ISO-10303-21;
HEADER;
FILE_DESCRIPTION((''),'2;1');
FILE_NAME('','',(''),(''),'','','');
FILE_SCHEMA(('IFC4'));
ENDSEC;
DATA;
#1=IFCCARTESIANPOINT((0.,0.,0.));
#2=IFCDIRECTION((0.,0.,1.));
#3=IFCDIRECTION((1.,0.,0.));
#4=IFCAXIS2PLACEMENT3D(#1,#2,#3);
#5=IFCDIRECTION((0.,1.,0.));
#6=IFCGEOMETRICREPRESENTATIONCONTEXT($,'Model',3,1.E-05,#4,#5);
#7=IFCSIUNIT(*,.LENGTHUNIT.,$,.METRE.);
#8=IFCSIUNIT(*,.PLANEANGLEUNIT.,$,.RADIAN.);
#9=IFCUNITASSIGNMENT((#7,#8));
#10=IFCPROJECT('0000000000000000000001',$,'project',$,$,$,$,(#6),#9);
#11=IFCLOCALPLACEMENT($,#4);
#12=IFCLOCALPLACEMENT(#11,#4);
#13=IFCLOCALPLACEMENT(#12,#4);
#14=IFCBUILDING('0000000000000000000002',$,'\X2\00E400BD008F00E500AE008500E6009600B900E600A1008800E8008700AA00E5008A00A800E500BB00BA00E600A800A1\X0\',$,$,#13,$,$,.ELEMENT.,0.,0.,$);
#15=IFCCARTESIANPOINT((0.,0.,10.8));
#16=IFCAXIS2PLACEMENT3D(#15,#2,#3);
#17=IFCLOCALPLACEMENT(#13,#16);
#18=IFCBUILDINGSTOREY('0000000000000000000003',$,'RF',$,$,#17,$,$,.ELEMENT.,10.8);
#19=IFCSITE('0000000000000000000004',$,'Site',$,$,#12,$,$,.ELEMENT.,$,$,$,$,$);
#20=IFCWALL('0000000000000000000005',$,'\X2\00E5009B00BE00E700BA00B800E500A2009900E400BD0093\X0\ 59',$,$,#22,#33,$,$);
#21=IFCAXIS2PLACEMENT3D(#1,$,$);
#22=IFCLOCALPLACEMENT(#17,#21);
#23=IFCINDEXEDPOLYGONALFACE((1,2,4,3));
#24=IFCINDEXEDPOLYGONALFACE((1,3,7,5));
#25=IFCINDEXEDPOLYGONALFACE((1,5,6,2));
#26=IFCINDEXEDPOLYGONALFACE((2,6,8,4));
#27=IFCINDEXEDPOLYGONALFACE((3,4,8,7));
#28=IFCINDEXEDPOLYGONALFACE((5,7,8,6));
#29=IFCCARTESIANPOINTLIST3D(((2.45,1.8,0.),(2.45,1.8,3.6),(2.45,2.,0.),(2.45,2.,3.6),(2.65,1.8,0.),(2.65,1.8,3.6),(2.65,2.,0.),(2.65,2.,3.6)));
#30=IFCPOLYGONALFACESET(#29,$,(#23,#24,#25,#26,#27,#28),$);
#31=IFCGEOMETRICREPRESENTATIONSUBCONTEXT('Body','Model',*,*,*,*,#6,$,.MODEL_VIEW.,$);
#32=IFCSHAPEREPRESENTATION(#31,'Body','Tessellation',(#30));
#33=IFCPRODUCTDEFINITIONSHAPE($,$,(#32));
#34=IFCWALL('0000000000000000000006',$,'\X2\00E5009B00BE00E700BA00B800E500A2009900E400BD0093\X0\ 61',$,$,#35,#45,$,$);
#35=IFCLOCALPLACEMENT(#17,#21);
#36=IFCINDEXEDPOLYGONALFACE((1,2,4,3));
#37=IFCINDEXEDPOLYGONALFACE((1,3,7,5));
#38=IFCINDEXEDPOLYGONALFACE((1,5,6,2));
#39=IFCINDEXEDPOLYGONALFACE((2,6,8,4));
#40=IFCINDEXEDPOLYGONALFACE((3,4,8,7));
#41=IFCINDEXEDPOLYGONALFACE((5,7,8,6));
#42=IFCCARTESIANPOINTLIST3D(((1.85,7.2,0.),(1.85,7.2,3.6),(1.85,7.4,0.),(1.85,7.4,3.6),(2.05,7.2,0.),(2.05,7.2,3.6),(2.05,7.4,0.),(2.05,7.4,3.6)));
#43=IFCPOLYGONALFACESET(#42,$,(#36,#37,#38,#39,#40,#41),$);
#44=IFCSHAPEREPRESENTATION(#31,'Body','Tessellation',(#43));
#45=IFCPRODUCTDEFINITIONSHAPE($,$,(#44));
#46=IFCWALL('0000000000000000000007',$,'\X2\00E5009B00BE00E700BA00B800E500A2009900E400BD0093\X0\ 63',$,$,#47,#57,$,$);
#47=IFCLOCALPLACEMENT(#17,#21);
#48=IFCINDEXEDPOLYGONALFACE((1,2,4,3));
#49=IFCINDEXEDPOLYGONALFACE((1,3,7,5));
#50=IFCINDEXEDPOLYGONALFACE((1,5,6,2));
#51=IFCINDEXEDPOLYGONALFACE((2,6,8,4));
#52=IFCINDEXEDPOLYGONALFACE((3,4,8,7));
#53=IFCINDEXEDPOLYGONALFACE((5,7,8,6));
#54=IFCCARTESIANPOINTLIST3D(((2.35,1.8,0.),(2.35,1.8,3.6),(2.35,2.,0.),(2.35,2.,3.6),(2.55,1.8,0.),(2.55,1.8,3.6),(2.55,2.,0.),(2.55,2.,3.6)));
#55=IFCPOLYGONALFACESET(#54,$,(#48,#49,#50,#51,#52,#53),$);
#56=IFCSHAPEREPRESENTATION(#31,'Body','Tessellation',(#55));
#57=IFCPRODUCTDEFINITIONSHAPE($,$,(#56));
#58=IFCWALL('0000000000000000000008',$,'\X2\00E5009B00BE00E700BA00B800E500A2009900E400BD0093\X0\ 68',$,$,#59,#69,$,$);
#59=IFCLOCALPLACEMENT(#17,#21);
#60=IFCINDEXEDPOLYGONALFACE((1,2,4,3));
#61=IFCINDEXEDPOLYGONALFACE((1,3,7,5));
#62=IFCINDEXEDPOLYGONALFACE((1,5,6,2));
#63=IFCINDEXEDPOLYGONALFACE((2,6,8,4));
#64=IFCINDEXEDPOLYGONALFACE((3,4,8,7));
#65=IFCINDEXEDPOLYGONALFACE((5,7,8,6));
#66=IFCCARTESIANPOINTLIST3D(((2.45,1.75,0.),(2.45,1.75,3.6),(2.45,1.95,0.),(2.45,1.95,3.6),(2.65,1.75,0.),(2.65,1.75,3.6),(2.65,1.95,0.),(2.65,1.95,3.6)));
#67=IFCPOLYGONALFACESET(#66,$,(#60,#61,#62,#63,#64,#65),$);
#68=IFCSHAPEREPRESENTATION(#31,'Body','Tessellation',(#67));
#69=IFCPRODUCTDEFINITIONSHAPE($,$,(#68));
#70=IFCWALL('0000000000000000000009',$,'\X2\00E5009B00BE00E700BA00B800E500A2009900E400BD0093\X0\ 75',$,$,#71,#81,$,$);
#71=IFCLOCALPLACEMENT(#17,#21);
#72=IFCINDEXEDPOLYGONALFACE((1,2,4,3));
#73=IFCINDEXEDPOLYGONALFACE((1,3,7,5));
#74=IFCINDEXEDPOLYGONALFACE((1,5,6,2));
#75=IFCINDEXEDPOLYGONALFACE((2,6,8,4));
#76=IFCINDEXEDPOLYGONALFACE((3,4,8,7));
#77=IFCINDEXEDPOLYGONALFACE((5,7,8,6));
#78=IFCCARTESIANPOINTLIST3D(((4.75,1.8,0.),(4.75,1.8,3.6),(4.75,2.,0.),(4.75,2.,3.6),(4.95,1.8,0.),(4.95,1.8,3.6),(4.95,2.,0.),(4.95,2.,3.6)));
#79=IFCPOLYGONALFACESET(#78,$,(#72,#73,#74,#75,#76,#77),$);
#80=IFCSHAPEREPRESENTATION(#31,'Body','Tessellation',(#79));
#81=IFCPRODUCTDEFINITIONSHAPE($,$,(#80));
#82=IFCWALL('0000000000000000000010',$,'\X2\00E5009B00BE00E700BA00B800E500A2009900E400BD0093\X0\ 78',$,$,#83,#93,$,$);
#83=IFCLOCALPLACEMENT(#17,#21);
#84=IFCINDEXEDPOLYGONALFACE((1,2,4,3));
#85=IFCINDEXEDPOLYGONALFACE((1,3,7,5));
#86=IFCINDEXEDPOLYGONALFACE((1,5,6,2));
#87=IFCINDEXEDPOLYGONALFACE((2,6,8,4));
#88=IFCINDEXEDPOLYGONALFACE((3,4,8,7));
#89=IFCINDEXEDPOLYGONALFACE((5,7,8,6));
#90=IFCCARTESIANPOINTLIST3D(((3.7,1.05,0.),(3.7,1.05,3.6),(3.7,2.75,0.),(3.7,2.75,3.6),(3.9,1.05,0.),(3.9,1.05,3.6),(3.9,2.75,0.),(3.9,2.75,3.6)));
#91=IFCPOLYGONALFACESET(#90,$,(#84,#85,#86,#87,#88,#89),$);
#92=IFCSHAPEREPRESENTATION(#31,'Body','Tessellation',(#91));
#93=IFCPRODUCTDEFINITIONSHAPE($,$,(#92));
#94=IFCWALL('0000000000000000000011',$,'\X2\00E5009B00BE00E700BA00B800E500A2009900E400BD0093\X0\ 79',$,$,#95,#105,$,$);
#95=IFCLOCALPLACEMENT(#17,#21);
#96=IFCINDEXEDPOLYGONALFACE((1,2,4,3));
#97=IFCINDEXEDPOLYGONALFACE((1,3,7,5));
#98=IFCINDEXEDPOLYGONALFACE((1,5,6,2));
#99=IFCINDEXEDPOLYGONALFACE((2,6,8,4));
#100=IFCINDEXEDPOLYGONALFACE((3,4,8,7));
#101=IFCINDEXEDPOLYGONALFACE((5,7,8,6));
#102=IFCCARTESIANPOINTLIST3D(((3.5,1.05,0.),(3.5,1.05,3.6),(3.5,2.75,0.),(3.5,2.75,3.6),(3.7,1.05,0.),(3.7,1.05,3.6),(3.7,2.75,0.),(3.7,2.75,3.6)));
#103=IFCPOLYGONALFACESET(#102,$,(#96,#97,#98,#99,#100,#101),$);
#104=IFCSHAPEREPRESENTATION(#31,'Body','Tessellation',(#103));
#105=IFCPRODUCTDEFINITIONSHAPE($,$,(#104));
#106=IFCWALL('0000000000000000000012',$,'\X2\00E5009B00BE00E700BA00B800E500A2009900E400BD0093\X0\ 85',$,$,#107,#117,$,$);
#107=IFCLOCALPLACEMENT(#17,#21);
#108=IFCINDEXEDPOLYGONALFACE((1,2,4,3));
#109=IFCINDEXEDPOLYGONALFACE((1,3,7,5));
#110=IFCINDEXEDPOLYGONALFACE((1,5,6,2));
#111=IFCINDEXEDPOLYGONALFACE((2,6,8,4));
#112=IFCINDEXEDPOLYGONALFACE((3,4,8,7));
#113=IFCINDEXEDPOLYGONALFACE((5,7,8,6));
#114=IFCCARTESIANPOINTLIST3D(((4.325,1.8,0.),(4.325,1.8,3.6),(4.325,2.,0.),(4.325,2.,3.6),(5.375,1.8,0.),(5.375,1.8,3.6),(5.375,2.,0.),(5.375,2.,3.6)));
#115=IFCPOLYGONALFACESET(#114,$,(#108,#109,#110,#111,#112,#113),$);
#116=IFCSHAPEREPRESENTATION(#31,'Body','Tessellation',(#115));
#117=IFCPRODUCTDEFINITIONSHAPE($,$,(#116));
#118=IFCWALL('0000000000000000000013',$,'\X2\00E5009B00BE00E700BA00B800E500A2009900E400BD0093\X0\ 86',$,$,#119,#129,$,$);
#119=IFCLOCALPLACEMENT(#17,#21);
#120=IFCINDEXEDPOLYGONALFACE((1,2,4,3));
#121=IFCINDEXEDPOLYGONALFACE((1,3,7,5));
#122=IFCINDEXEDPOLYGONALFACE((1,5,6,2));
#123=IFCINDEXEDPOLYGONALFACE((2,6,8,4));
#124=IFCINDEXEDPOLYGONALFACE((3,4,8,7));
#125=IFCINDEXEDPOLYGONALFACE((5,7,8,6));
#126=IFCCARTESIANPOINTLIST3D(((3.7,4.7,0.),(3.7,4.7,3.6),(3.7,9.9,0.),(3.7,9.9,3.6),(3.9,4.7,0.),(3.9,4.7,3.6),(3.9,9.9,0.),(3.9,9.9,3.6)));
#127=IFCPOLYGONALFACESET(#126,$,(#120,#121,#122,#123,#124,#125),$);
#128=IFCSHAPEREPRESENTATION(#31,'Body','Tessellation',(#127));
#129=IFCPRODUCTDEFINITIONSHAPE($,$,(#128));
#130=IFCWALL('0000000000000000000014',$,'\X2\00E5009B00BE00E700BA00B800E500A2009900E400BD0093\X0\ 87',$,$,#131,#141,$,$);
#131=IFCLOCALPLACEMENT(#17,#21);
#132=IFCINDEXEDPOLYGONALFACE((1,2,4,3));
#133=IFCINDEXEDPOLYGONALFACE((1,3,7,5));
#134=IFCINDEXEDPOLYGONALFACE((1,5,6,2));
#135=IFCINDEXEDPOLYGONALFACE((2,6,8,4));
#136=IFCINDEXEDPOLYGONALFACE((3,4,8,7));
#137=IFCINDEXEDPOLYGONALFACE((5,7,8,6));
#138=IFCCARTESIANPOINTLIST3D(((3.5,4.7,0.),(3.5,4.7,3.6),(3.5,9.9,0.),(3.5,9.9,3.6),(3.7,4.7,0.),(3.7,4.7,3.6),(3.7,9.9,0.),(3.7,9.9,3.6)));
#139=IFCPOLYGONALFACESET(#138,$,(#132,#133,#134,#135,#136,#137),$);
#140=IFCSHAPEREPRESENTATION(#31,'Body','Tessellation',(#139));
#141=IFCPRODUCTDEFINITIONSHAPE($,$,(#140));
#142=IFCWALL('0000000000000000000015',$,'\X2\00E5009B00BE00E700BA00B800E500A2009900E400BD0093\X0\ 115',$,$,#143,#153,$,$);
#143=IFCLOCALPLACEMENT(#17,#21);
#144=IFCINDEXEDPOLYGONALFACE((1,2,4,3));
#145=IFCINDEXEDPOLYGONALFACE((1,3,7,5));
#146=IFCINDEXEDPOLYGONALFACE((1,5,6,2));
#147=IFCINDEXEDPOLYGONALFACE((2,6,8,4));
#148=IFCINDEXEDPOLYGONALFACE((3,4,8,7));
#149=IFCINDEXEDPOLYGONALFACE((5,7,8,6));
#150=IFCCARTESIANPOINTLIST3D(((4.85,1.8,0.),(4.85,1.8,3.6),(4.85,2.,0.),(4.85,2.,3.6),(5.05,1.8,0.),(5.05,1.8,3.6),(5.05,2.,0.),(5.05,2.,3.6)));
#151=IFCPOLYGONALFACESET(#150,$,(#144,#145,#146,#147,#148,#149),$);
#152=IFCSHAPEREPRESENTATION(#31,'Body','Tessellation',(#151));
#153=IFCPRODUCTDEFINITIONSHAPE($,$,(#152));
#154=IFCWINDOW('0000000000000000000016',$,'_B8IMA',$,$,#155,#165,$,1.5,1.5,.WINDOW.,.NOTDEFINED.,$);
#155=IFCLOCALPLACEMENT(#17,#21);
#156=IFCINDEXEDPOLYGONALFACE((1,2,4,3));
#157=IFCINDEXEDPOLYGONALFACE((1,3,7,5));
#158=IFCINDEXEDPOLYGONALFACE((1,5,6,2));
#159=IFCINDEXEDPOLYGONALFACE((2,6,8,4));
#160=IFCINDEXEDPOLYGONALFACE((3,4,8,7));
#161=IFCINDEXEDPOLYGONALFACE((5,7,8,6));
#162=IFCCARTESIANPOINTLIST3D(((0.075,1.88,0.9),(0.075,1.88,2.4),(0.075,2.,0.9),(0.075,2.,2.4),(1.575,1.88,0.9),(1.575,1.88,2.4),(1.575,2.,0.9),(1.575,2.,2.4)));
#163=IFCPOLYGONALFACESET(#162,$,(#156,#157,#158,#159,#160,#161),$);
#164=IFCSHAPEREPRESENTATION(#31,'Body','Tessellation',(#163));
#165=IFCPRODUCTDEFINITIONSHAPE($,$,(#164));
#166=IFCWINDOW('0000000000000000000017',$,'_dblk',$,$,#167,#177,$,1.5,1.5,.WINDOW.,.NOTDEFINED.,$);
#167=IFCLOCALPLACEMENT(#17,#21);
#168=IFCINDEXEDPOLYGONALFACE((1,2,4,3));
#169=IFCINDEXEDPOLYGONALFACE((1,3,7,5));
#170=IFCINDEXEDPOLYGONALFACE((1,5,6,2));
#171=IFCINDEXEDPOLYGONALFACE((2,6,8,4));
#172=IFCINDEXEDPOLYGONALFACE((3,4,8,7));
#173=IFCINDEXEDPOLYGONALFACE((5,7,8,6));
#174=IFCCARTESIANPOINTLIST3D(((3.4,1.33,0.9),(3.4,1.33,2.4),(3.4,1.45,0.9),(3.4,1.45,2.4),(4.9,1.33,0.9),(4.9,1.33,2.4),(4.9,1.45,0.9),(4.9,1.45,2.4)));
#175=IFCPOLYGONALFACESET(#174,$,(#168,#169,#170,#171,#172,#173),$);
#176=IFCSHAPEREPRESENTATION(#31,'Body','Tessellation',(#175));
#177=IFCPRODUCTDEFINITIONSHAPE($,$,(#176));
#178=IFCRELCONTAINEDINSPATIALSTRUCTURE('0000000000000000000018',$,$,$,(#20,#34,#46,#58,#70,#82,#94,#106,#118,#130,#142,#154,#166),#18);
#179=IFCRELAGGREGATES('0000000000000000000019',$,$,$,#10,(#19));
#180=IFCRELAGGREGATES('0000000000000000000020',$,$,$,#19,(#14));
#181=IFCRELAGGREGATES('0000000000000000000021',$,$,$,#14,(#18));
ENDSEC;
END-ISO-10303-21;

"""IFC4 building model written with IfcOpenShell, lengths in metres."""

from ifc_helpers import new_model, si_unit, direction, frame, frame_2d, origin_with_axes, place, context, subcontext, project, spatial, rectangle, extrude, element, save


model = new_model("IFC4")

# Units and contexts
model_context = context("Model", 3, precision=1e-05, world=origin_with_axes(), true_north=direction((0.0, 1.0, 0.0)))
body_context = subcontext(model_context, "Body", "Model", "MODEL_VIEW")
ifc_project = project(units=[si_unit("LENGTHUNIT", "METRE"), si_unit("PLANEANGLEUNIT", "RADIAN")], contexts=[model_context])

# Site, building, storey
placement = place(None, origin_with_axes())
site_placement = place(placement, origin_with_axes())
site = spatial("IfcSite", under=ifc_project, at=site_placement, Name="Site", CompositionType="ELEMENT")
building_placement = place(site_placement, origin_with_axes())
building = spatial("IfcBuilding", under=site, at=building_placement, Name="ä½\u008få®\u0085æ\u0096¹æ¡\u0088è\u0087ªå\u008a¨å»ºæ¨¡", CompositionType="ELEMENT", ElevationOfRefHeight=0.0, ElevationOfTerrain=0.0)
storey_placement = place(building_placement, frame((0.0, 0.0, 10.8), z_axis=(0.0, 0.0, 1.0), x_axis=(1.0, 0.0, 0.0)))
storey = spatial("IfcBuildingStorey", under=building, at=storey_placement, Name="RF", CompositionType="ELEMENT", Elevation=10.8)

# Walls
for number, where, z_axis, x_axis, name in (
    (1, (2.55, 1.9, 0.0), (0.0, 0.0, 1.0), (0.0, -1.0, 0.0), "å\u009b¾çº¸å¢\u0099ä½\u0093 59"),
    (2, (1.95, 7.3, 0.0), (0.0, 0.0, 1.0), (0.0, 1.0, 0.0), "å\u009b¾çº¸å¢\u0099ä½\u0093 61"),
    (3, (2.45, 1.9, 0.0), (0.0, 0.0, 1.0), (0.0, 1.0, 0.0), "å\u009b¾çº¸å¢\u0099ä½\u0093 63"),
    (4, (2.55, 1.85, 0.0), (0.0, 0.0, 1.0), (-1.0, 0.0, 0.0), "å\u009b¾çº¸å¢\u0099ä½\u0093 68"),
    (5, (4.85, 1.9, 0.0), (0.0, 0.0, 1.0), (0.0, -1.0, 0.0), "å\u009b¾çº¸å¢\u0099ä½\u0093 75"),
):
    element("IfcWall", number, at=place(storey_placement, frame(where, z_axis=z_axis, x_axis=x_axis)), inside=storey, Name=name, context=body_context, shape_type="SweptSolid", body=[
        extrude(rectangle(XDim=0.2, YDim=0.2, at=frame_2d((0.0, 0.0), x_axis=(1.0, 0.0, 0.0))), frame((0.0, 0.0, 0.0), z_axis=(0.0, 0.0, 1.0)), (0.0, 0.0, 1.0), 3.6),
    ])
for number, where, z_axis, x_axis, name in (
    (6, (3.8, 1.9, 0.0), (0.0, 0.0, 1.0), (0.0, -1.0, 0.0), "å\u009b¾çº¸å¢\u0099ä½\u0093 78"),
    (7, (3.6, 1.9, 0.0), (0.0, 0.0, 1.0), (0.0, -1.0, 0.0), "å\u009b¾çº¸å¢\u0099ä½\u0093 79"),
):
    element("IfcWall", number, at=place(storey_placement, frame(where, z_axis=z_axis, x_axis=x_axis)), inside=storey, Name=name, context=body_context, shape_type="SweptSolid", body=[
        extrude(rectangle(XDim=1.7, YDim=0.2, at=frame_2d((0.0, 0.0), x_axis=(1.0, 0.0, 0.0))), frame((0.0, 0.0, 0.0), z_axis=(0.0, 0.0, 1.0)), (0.0, 0.0, 1.0), 3.6),
    ])
wall_1_placement = place(storey_placement, frame((4.85, 1.9, 0.0), z_axis=(0.0, 0.0, 1.0), x_axis=(-1.0, 0.0, 0.0)))
element("IfcWall", 8, at=wall_1_placement, inside=storey, Name="å\u009b¾çº¸å¢\u0099ä½\u0093 85", context=body_context, shape_type="SweptSolid", body=[
    extrude(rectangle(XDim=1.05, YDim=0.2, at=frame_2d((0.0, 0.0), x_axis=(1.0, 0.0, 0.0))), frame((0.0, 0.0, 0.0), z_axis=(0.0, 0.0, 1.0)), (0.0, 0.0, 1.0), 3.6),
])
for number, where, z_axis, x_axis, name in (
    (9, (3.8, 7.3, 0.0), (0.0, 0.0, 1.0), (0.0, -1.0, 0.0), "å\u009b¾çº¸å¢\u0099ä½\u0093 86"),
    (10, (3.6, 7.3, 0.0), (0.0, 0.0, 1.0), (0.0, -1.0, 0.0), "å\u009b¾çº¸å¢\u0099ä½\u0093 87"),
):
    element("IfcWall", number, at=place(storey_placement, frame(where, z_axis=z_axis, x_axis=x_axis)), inside=storey, Name=name, context=body_context, shape_type="SweptSolid", body=[
        extrude(rectangle(XDim=5.2, YDim=0.2, at=frame_2d((0.0, 0.0), x_axis=(1.0, 0.0, 0.0))), frame((0.0, 0.0, 0.0), z_axis=(0.0, 0.0, 1.0)), (0.0, 0.0, 1.0), 3.6),
    ])
wall_2_placement = place(storey_placement, frame((4.95, 1.9, 0.0), z_axis=(0.0, 0.0, 1.0), x_axis=(0.0, 1.0, 0.0)))
element("IfcWall", 11, at=wall_2_placement, inside=storey, Name="å\u009b¾çº¸å¢\u0099ä½\u0093 115", context=body_context, shape_type="SweptSolid", body=[
    extrude(rectangle(XDim=0.2, YDim=0.2, at=frame_2d((0.0, 0.0), x_axis=(1.0, 0.0, 0.0))), frame((0.0, 0.0, 0.0), z_axis=(0.0, 0.0, 1.0)), (0.0, 0.0, 1.0), 3.6),
])

# Windows
for number, where, z_axis, x_axis, name in (
    (12, (0.825, 1.94, 0.9), (0.0, 0.0, 1.0), (1.0, 0.0, 0.0), "_B8IMA"),
    (13, (4.15, 1.39, 0.9), (0.0, 0.0, 1.0), (1.0, 0.0, 0.0), "_dblk"),
):
    element("IfcWindow", number, at=place(storey_placement, frame(where, z_axis=z_axis, x_axis=x_axis)), inside=storey, Name=name, OverallHeight=1.5, OverallWidth=1.5, PartitioningType="NOTDEFINED", PredefinedType="WINDOW", context=body_context, shape_type="SweptSolid", body=[
        extrude(rectangle(XDim=1.5, YDim=0.12, at=frame_2d((0.0, 0.0), x_axis=(1.0, 0.0, 0.0))), frame((0.0, 0.0, 0.0), z_axis=(0.0, 0.0, 1.0)), (0.0, 0.0, 1.0), 1.5),
    ])

save(model, "model.ifc")
